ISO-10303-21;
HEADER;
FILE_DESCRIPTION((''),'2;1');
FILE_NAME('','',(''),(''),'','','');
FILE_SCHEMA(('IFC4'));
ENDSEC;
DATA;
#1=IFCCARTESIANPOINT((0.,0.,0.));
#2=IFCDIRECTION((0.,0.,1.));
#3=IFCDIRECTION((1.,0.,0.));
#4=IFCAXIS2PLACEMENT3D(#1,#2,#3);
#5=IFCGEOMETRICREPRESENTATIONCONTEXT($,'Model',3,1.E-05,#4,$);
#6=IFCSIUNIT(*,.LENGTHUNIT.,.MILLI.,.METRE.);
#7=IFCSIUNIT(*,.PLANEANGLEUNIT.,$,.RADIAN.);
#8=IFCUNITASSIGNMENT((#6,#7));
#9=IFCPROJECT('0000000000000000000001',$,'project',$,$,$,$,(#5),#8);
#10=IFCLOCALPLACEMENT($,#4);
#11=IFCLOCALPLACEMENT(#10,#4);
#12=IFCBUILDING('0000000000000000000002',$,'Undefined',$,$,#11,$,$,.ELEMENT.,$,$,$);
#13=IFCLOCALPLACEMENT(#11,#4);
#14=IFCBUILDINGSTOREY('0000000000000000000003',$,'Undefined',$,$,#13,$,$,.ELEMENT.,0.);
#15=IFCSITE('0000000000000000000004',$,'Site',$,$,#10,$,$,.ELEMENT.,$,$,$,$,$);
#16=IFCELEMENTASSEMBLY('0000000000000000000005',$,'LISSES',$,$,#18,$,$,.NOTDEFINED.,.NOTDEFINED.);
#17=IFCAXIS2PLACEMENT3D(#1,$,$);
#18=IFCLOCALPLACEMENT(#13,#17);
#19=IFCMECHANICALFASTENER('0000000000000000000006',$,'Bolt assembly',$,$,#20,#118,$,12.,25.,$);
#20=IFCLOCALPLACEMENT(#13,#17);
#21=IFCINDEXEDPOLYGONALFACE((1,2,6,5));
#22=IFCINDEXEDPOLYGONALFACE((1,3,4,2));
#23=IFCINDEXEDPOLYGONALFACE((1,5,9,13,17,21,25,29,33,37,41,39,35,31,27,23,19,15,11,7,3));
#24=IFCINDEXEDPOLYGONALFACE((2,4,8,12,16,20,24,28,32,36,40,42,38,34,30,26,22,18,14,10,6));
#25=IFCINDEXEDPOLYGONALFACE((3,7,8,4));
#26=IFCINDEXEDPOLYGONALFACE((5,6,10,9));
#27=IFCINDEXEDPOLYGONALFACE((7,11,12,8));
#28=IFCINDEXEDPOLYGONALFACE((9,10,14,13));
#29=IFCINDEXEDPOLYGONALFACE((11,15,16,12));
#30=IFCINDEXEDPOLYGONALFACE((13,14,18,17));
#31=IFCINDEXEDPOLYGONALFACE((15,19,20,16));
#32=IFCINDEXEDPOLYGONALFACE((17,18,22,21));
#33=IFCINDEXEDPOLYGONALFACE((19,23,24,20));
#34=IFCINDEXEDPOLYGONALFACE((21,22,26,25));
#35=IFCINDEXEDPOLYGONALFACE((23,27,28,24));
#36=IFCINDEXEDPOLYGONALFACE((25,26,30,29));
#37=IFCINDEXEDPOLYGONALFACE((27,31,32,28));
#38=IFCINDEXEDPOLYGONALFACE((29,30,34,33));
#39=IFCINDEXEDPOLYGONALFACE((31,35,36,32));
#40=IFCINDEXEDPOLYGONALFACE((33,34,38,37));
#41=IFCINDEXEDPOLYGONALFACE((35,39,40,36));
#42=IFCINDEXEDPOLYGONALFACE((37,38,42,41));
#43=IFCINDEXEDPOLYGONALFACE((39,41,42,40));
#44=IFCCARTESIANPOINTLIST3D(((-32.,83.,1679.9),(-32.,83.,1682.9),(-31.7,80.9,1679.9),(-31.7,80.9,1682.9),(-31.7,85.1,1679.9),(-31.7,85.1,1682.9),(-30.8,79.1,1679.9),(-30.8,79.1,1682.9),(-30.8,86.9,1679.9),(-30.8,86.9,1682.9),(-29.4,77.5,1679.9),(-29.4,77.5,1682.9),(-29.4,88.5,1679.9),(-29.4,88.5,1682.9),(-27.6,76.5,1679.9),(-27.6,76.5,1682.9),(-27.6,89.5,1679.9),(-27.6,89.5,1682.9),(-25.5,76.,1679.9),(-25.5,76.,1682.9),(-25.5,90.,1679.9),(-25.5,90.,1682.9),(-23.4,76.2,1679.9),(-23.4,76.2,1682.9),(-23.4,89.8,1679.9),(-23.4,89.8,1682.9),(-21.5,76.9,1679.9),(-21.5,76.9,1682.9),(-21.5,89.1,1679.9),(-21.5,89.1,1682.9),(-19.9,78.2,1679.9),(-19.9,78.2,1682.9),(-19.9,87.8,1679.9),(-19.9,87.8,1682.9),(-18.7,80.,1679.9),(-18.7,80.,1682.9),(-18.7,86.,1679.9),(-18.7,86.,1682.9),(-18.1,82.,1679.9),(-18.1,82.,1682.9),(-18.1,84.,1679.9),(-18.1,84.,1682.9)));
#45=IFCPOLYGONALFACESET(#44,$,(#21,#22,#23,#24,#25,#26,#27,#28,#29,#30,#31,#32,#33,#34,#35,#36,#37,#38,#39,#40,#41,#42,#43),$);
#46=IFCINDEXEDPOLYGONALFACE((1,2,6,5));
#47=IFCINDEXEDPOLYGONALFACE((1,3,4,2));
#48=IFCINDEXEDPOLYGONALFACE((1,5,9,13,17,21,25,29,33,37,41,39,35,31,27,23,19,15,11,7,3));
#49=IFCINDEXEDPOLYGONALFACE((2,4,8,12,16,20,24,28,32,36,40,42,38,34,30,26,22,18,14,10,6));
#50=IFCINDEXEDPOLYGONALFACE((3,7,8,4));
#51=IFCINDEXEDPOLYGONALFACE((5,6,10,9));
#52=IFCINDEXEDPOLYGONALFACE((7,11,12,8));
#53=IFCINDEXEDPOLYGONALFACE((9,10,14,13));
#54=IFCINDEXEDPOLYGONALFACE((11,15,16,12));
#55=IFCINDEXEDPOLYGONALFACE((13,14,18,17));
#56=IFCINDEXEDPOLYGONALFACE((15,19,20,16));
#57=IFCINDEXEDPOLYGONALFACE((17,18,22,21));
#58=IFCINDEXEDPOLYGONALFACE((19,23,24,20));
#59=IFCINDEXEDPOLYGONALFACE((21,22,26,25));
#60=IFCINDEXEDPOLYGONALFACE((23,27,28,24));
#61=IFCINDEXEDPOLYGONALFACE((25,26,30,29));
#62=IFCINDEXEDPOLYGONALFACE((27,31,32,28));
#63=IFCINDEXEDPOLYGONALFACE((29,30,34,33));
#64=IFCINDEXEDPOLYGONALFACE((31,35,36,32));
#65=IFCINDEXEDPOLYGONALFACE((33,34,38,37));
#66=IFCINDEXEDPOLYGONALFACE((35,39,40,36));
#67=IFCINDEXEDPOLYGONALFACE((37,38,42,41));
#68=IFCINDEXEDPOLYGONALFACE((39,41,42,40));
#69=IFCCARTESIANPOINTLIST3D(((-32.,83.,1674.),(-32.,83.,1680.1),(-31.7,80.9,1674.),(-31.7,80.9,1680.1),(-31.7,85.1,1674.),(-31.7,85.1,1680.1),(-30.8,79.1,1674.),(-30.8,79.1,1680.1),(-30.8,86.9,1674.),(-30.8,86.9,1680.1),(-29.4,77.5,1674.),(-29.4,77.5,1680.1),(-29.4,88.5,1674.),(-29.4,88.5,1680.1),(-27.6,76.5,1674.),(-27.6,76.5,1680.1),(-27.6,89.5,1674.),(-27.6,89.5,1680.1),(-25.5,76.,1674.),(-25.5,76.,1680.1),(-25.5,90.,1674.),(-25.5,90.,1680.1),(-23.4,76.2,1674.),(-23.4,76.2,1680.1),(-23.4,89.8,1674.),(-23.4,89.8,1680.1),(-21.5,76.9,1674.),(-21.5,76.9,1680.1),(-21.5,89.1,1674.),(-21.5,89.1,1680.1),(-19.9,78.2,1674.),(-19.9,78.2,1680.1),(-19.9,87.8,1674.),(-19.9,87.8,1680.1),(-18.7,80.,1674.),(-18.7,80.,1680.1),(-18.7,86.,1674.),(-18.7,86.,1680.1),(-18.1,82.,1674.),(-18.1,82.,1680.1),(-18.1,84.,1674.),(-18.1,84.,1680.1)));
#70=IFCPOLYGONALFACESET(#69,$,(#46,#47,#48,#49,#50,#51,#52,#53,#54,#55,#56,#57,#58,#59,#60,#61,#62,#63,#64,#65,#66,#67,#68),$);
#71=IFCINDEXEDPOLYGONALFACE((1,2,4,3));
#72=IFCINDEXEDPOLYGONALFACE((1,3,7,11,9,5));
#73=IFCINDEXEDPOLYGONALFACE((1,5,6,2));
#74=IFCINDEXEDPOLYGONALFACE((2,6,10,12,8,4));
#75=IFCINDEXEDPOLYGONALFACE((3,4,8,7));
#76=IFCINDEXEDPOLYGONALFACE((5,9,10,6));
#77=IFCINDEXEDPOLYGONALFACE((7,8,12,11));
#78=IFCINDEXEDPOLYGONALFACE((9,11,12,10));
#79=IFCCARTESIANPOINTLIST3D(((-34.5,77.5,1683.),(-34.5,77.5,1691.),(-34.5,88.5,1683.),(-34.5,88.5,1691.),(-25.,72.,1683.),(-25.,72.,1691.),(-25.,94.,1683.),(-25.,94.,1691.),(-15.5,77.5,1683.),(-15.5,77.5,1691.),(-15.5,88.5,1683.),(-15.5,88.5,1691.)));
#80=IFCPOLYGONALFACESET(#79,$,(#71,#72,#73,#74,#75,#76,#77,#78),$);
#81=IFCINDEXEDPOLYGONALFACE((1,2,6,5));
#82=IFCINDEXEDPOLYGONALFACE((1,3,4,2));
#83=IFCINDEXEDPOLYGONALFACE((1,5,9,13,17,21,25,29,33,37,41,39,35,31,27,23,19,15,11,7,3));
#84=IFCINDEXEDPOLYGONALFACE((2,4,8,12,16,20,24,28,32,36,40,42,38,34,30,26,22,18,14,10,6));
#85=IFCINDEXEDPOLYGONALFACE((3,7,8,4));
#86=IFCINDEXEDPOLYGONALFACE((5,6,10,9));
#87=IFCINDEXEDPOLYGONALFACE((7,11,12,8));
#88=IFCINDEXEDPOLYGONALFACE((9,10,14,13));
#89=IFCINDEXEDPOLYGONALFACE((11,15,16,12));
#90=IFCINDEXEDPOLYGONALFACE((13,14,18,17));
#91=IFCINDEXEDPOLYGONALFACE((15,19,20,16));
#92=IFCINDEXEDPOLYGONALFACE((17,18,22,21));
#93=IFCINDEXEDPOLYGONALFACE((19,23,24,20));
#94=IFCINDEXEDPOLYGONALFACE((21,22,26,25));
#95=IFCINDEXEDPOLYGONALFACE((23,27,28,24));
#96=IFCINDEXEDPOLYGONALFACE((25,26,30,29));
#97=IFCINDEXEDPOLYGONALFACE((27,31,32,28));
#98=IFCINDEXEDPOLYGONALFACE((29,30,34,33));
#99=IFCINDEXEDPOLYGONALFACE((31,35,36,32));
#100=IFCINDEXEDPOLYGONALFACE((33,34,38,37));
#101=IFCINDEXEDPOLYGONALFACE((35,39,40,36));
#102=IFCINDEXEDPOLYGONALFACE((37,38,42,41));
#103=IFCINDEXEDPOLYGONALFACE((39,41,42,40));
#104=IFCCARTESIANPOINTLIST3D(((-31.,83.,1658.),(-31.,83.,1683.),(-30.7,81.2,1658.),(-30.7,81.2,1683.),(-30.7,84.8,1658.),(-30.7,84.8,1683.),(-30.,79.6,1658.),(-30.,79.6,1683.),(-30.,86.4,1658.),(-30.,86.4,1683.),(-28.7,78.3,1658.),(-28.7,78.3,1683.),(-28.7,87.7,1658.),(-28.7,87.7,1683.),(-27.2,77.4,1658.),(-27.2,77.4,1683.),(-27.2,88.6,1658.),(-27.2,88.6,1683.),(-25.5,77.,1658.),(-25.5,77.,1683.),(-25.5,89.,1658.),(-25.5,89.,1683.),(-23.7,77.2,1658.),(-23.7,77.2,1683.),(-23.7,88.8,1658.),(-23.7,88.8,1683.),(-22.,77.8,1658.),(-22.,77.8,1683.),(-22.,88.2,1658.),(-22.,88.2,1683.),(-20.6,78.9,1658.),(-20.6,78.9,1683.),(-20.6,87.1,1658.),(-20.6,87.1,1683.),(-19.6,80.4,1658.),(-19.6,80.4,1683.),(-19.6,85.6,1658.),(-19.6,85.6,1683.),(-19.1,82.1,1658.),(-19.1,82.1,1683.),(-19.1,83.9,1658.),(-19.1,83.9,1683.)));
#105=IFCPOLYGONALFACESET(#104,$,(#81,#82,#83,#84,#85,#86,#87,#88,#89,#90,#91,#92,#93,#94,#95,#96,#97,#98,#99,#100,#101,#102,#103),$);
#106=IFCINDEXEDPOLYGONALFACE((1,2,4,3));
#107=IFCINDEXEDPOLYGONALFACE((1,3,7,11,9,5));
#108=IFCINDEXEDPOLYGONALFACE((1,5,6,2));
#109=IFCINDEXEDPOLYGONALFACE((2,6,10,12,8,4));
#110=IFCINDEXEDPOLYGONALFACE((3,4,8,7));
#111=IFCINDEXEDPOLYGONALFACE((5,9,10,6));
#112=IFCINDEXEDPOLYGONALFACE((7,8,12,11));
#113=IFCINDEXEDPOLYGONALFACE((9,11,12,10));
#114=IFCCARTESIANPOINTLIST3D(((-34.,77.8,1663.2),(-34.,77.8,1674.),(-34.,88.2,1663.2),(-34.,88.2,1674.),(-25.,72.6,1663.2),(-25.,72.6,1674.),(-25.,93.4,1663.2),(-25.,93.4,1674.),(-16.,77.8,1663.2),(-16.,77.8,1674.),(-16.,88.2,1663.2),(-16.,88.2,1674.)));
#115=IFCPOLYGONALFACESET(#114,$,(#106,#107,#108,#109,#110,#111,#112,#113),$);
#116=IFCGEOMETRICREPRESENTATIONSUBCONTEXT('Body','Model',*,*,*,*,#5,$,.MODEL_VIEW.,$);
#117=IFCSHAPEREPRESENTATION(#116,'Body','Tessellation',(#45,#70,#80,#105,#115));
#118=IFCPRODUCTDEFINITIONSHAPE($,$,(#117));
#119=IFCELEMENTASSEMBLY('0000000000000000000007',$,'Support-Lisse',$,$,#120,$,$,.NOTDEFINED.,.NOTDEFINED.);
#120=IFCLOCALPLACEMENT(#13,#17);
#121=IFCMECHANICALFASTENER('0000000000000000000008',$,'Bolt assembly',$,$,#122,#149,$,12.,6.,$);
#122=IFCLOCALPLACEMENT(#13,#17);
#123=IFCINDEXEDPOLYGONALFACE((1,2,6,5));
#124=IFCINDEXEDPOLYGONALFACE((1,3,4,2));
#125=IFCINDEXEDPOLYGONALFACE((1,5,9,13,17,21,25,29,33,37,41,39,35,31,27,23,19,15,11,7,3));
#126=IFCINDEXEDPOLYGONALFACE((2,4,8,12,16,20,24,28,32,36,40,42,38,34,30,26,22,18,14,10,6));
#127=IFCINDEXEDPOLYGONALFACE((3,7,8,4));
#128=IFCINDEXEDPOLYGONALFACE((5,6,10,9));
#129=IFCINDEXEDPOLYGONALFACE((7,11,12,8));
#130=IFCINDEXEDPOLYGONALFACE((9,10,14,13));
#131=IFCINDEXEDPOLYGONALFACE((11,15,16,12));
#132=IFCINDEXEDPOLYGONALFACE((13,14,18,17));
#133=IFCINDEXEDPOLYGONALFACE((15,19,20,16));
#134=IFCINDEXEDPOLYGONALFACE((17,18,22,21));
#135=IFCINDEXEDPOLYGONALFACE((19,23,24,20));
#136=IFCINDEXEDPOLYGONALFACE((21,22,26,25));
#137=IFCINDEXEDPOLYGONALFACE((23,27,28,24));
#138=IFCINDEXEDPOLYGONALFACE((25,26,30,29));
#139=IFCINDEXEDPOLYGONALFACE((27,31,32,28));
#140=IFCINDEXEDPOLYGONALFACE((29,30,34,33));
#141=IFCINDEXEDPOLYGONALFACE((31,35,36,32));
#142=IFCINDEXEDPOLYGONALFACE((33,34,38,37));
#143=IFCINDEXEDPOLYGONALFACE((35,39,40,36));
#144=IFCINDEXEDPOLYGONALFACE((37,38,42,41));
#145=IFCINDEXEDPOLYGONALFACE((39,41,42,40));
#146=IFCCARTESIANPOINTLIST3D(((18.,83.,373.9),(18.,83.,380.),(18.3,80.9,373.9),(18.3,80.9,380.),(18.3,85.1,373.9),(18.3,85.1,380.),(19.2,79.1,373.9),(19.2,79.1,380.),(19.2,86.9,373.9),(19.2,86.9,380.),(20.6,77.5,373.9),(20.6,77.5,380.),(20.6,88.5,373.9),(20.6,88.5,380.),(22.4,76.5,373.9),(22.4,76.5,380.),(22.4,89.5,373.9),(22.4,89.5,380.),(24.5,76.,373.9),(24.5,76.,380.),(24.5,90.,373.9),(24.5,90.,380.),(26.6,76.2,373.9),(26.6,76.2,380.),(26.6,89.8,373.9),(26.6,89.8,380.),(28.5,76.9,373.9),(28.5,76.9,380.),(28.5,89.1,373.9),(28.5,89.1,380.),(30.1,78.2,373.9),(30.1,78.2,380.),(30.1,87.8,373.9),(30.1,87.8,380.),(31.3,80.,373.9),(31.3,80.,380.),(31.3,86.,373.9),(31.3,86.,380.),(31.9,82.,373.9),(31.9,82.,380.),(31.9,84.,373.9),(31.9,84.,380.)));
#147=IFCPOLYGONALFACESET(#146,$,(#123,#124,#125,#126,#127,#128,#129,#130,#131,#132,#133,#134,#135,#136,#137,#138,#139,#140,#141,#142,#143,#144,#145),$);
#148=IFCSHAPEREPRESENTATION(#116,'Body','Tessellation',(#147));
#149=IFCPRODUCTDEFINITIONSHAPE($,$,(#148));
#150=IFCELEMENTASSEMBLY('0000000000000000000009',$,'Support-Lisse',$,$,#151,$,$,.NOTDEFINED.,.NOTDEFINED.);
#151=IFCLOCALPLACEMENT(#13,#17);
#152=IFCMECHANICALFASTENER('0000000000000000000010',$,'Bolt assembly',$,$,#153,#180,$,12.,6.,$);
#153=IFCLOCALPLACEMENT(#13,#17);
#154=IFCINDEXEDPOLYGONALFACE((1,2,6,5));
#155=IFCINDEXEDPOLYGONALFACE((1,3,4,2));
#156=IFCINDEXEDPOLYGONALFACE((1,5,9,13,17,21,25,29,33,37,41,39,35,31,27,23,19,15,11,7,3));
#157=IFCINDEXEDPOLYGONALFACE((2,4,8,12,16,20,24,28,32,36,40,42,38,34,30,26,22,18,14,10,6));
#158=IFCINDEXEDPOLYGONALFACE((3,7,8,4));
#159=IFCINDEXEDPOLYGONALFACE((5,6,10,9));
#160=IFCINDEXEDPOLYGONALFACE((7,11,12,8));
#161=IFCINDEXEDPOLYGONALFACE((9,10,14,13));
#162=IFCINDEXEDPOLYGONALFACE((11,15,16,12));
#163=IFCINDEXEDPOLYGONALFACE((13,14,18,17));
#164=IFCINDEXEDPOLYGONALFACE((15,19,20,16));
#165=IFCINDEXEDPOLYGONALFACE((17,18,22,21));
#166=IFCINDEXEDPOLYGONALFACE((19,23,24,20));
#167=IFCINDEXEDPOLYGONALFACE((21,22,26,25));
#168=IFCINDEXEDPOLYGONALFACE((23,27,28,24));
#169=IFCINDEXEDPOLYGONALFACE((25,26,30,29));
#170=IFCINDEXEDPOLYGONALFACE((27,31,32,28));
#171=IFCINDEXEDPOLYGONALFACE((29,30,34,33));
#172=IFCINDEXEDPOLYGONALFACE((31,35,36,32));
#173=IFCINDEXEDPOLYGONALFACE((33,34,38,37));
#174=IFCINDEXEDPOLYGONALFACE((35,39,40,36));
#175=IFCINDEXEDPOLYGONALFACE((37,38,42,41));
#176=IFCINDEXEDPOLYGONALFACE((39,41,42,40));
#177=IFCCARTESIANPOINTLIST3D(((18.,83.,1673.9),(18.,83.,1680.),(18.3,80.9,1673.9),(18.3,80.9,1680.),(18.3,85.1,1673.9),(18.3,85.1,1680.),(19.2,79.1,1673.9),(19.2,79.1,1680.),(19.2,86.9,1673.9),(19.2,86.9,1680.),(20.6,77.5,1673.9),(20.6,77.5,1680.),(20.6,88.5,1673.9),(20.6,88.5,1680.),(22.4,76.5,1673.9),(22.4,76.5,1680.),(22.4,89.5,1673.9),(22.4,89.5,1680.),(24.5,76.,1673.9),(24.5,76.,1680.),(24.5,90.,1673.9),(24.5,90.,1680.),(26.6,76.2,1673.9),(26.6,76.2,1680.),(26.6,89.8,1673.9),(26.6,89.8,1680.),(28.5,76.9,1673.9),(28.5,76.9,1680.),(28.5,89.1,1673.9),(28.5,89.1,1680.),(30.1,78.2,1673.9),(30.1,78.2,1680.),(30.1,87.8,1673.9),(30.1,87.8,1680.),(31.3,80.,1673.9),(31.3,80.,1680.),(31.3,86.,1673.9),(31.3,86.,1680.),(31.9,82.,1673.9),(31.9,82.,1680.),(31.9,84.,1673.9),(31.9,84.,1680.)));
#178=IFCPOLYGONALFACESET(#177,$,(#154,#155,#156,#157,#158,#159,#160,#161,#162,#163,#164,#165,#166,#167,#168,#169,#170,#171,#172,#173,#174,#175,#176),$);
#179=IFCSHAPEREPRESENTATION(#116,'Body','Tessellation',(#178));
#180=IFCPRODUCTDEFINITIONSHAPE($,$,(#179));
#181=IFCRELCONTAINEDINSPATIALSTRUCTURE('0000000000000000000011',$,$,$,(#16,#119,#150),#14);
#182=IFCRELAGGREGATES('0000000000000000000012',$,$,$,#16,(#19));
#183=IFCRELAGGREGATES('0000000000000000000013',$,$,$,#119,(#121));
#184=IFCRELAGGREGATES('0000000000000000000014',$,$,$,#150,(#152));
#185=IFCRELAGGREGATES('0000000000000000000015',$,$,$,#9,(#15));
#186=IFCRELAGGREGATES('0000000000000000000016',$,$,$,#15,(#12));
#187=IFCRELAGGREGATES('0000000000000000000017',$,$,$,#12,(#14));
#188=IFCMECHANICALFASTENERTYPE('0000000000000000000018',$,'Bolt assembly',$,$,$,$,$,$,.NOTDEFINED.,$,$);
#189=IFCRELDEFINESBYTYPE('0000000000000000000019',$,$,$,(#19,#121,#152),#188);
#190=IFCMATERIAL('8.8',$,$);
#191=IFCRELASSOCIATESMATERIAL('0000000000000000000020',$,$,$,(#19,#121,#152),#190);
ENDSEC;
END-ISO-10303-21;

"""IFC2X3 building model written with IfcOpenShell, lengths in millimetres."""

from ifc_helpers import new_model, si_unit, frame, origin_with_axes, origin_2d_with_axis, place, context, subcontext, project, spatial, polyline, circle, outline, extrude, source, transform, mapped, material, type_object, element, aggregate, save


model = new_model("IFC2X3")

# Units and contexts
model_context = context("Model", 3, precision=1e-05, world=origin_with_axes())
body_context = subcontext(model_context, "Body", "Model", "MODEL_VIEW")
ifc_project = project(units=[si_unit("LENGTHUNIT", "METRE", prefix="MILLI"), si_unit("PLANEANGLEUNIT", "RADIAN")], contexts=[model_context])

# Site, building, storey
site_placement = place(None, origin_with_axes())
site = spatial("IfcSite", under=ifc_project, at=site_placement, Name="Site", CompositionType="ELEMENT")
building_placement = place(site_placement, origin_with_axes())
building = spatial("IfcBuilding", under=site, at=building_placement, Name="Undefined", CompositionType="ELEMENT")
storey_placement = place(building_placement, origin_with_axes())
storey = spatial("IfcBuildingStorey", under=building, at=storey_placement, Name="Undefined", CompositionType="ELEMENT", Elevation=0.0)

# Shared definitions
ifc_material_1 = material(Name="8.8")
mechanical_fastener_type = type_object("IfcMechanicalFastenerType", Name="Bolt assembly")

# Element assemblies, mechanical fasteners
assembly_1_placement = place(storey_placement, origin_with_axes())
assembly_1 = element("IfcElementAssembly", 1, at=assembly_1_placement, inside=storey, Name="LISSES", AssemblyPlace="NOTDEFINED", PredefinedType="NOTDEFINED")
shared_shape_1 = source(origin_with_axes(), body_context, "Body", "SweptSolid", [
    extrude(circle(Radius=7.0, at=origin_2d_with_axis()), frame((0.0, -5.9, 0.0), z_axis=(0.0, 1.0, 0.0), x_axis=(1.0, 0.0, 0.0)), (0.0, 0.0, 1.0), 3.0),
    extrude(circle(Radius=7.0, at=origin_2d_with_axis()), frame((0.0, -3.1, 0.0), z_axis=(0.0, 1.0, 0.0), x_axis=(1.0, 0.0, 0.0)), (0.0, 0.0, 1.0), 6.1),
    extrude(outline(polyline([(9.5, -5.5), (9.5, 5.5), (0.0, 11.0), (-9.5, 5.5), (-9.5, -5.5), (0.0, -11.0), (9.5, -5.5)])), frame((0.0, -14.0, 0.0), z_axis=(0.0, 1.0, 0.0), x_axis=(1.0, 0.0, 0.0)), (0.0, 0.0, 1.0), 8.0),
    extrude(circle(Radius=6.0, at=origin_2d_with_axis()), frame((0.0, -6.0, 0.0), z_axis=(0.0, 1.0, 0.0), x_axis=(1.0, 0.0, 0.0)), (0.0, 0.0, 1.0), 25.0),
    extrude(outline(polyline([(9.0, -5.2), (9.0, 5.2), (0.0, 10.4), (-9.0, 5.2), (-9.0, -5.2), (0.0, -10.4), (9.0, -5.2)])), frame((0.0, 3.0, 0.0), z_axis=(0.0, 1.0, 0.0), x_axis=(1.0, 0.0, 0.0)), (0.0, 0.0, 1.0), 10.8),
])
mechanical_fastener_1_placement = place(assembly_1_placement, frame((-25.0, 83.0, 1677.0), z_axis=(0.0, -1.0, 0.0), x_axis=(-1.0, 0.0, 0.0)))
mechanical_fastener_1 = element("IfcMechanicalFastener", 2, at=mechanical_fastener_1_placement, type_object=mechanical_fastener_type, material=ifc_material_1, Name="Bolt assembly", NominalDiameter=12.0, NominalLength=25.0, context=body_context, shape_type="MappedRepresentation", body=[
    mapped(shared_shape_1, transform((0.0, 0.0, 0.0))),
])
aggregate(assembly_1, [mechanical_fastener_1])
assembly_2_placement = place(storey_placement, origin_with_axes())
assembly_2 = element("IfcElementAssembly", 3, at=assembly_2_placement, inside=storey, Name="Support-Lisse", AssemblyPlace="NOTDEFINED", PredefinedType="NOTDEFINED")
shared_shape_2 = source(origin_with_axes(), body_context, "Body", "SweptSolid", [
    extrude(circle(Radius=7.0, at=origin_2d_with_axis()), frame((0.0, 0.0, 0.0), z_axis=(0.0, 1.0, 0.0), x_axis=(1.0, 0.0, 0.0)), (0.0, 0.0, 1.0), 6.1),
])
mechanical_fastener_2_placement = place(assembly_2_placement, frame((25.0, 83.0, 380.0), z_axis=(0.0, -1.0, 0.0), x_axis=(-1.0, 0.0, 0.0)))
mechanical_fastener_2 = element("IfcMechanicalFastener", 4, at=mechanical_fastener_2_placement, type_object=mechanical_fastener_type, material=ifc_material_1, Name="Bolt assembly", NominalDiameter=12.0, NominalLength=6.0, context=body_context, shape_type="MappedRepresentation", body=[
    mapped(shared_shape_2, transform((0.0, 0.0, 0.0))),
])
aggregate(assembly_2, [mechanical_fastener_2])
assembly_3_placement = place(storey_placement, origin_with_axes())
assembly_3 = element("IfcElementAssembly", 5, at=assembly_3_placement, inside=storey, Name="Support-Lisse", AssemblyPlace="NOTDEFINED", PredefinedType="NOTDEFINED")
mechanical_fastener_3_placement = place(assembly_3_placement, frame((25.0, 83.0, 1680.0), z_axis=(0.0, -1.0, 0.0), x_axis=(-1.0, 0.0, 0.0)))
mechanical_fastener_3 = element("IfcMechanicalFastener", 6, at=mechanical_fastener_3_placement, type_object=mechanical_fastener_type, material=ifc_material_1, Name="Bolt assembly", NominalDiameter=12.0, NominalLength=6.0, context=body_context, shape_type="MappedRepresentation", body=[
    mapped(shared_shape_2, transform((0.0, 0.0, 0.0))),
])
aggregate(assembly_3, [mechanical_fastener_3])

save(model, "model.ifc")
